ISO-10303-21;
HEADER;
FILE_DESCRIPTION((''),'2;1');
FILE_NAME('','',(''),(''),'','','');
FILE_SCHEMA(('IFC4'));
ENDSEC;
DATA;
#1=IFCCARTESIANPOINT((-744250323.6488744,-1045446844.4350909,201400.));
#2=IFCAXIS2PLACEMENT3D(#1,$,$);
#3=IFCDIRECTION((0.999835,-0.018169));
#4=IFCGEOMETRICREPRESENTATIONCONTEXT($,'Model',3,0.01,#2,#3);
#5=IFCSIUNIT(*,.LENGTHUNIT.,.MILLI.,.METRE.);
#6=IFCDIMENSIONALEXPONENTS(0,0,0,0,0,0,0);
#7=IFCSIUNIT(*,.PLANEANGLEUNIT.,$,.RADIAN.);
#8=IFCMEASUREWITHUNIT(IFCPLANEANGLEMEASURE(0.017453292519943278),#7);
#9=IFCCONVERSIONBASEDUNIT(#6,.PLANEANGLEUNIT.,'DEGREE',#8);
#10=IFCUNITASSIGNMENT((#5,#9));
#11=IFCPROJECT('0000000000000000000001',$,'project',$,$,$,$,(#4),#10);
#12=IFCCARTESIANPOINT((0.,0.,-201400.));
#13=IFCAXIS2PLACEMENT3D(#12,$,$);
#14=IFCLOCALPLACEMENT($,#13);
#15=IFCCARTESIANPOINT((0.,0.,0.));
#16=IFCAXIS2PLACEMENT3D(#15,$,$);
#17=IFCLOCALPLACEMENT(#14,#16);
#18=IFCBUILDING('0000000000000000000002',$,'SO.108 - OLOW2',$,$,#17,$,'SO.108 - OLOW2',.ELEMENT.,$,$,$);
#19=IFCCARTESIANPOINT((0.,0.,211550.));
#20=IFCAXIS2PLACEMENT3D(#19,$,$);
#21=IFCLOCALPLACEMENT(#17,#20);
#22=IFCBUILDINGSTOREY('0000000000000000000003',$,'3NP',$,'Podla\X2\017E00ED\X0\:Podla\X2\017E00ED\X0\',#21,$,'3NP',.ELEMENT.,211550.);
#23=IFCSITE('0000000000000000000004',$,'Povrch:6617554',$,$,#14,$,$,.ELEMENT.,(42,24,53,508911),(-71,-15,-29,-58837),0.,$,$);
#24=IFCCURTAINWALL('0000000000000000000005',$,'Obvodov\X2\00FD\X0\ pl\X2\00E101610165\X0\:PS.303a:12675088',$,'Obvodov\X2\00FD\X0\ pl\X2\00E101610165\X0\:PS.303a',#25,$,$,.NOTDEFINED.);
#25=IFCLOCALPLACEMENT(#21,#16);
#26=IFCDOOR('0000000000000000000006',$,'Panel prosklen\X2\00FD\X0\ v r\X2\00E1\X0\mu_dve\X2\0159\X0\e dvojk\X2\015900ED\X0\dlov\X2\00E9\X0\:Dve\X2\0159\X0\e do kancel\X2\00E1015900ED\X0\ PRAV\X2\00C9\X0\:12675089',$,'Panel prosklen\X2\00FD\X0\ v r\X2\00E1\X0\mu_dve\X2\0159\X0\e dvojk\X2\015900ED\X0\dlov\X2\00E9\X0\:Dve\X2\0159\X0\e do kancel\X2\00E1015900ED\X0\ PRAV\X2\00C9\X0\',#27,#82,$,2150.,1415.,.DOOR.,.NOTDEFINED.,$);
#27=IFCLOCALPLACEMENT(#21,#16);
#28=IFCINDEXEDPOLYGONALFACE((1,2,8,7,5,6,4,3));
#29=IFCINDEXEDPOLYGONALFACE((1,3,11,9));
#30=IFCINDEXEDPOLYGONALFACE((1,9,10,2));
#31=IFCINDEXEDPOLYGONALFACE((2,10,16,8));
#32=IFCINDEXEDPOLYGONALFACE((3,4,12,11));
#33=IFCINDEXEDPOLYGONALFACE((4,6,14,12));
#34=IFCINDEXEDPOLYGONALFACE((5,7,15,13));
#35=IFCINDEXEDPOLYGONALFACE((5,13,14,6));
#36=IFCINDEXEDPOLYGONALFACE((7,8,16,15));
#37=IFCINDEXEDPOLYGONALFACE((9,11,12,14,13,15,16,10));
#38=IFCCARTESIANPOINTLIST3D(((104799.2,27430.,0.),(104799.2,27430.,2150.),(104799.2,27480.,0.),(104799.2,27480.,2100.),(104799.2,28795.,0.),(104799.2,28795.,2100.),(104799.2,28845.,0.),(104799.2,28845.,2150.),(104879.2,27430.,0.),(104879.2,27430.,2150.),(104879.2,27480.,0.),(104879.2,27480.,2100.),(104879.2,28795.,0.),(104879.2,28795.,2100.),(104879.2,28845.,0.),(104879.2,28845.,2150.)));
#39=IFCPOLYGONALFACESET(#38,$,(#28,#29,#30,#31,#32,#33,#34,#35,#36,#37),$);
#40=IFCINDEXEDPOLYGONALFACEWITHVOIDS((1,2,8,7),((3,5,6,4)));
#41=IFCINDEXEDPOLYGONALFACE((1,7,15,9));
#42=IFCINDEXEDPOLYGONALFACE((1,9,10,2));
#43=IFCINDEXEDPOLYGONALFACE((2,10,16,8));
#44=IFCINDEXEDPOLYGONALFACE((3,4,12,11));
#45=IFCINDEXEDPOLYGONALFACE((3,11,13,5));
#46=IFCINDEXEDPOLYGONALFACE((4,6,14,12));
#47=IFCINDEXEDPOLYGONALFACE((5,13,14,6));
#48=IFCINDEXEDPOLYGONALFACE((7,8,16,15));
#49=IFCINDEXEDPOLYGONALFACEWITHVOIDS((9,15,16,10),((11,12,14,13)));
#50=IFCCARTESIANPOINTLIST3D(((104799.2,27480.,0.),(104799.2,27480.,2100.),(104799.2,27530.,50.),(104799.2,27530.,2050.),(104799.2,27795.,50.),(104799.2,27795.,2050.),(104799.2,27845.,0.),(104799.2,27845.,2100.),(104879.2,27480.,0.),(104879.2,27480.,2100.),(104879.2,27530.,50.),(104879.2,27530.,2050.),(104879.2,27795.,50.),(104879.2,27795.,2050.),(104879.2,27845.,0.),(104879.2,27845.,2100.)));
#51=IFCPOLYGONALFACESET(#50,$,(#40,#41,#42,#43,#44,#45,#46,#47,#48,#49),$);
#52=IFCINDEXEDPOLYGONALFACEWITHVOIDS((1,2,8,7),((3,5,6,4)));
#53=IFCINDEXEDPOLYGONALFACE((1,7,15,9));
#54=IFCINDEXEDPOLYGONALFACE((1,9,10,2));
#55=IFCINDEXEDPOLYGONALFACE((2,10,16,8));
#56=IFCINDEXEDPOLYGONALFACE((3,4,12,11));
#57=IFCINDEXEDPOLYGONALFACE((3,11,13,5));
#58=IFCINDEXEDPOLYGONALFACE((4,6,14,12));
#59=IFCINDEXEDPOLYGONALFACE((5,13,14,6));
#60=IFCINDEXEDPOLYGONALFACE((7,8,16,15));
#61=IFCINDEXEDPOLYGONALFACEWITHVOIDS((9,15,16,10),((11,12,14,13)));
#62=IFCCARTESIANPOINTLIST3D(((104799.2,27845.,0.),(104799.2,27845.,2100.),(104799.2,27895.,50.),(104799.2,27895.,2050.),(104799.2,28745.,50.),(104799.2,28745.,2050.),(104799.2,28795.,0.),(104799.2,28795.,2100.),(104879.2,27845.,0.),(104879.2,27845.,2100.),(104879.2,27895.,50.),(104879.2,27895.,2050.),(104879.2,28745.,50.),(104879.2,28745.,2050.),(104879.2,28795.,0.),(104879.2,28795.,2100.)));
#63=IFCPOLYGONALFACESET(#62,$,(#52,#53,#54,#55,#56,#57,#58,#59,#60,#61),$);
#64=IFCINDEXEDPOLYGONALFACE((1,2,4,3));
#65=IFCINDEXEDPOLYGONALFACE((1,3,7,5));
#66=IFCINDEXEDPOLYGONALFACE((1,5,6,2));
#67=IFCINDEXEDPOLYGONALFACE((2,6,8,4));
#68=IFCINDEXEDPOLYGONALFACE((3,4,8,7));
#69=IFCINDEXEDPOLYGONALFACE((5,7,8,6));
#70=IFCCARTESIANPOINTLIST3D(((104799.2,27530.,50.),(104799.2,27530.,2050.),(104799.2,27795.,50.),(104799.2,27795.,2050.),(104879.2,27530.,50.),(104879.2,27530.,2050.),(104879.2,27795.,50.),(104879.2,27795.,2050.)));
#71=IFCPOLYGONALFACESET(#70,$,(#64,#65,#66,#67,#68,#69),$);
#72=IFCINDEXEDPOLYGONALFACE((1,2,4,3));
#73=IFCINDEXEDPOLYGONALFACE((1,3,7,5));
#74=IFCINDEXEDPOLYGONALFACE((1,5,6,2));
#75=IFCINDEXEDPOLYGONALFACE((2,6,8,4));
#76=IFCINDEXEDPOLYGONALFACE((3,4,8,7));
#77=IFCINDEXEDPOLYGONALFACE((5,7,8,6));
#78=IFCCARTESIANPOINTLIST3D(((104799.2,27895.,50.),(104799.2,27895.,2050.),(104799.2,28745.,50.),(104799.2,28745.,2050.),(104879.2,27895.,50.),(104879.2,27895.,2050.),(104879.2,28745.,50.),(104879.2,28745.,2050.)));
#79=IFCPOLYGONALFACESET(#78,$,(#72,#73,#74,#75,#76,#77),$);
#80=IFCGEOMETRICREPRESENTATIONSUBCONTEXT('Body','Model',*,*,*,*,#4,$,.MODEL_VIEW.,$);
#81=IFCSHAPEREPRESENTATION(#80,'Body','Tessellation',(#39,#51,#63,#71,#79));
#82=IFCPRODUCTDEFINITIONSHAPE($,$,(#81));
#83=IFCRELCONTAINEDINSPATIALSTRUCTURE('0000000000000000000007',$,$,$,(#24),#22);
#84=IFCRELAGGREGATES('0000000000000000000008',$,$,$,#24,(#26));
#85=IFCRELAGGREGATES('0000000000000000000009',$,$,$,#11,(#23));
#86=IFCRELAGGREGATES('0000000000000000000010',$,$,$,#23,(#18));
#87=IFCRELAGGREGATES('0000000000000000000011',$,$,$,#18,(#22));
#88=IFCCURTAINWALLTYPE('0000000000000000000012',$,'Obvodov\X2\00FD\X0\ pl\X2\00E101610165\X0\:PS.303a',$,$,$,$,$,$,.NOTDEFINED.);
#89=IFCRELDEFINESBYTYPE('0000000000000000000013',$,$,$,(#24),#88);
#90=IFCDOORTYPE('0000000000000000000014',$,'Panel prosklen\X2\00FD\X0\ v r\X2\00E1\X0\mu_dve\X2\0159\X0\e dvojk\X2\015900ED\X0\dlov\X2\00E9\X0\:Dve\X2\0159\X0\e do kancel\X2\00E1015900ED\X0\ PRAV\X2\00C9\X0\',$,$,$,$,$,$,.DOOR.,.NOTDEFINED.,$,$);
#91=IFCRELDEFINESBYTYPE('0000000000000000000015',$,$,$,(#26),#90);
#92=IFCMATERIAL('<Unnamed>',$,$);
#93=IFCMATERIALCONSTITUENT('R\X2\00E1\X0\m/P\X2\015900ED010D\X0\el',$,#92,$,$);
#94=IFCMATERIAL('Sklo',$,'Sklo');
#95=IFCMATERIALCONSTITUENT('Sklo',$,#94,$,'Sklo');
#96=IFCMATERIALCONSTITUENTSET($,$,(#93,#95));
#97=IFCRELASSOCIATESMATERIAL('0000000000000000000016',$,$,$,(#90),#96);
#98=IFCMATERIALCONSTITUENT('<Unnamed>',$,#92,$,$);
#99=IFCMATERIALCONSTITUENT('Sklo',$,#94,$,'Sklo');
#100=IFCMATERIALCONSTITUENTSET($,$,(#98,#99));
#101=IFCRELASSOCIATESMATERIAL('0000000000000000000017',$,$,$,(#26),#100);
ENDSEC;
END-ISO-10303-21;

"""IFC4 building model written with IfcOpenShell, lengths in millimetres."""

from ifc_helpers import new_model, entity, si_unit, converted_unit, direction, frame, origin, place, context, subcontext, project, spatial, indexed_curve, outline, extrude, source, transform, mapped, material, constituent, constituent_set, type_object, type_shapes, element, aggregate, save


model = new_model("IFC4")

# Units and contexts
model_context = context("Model", 3, precision=0.01, world=frame((-744250323.6488744, -1045446844.4350909, 201400.0)), true_north=direction((0.999835, -0.018169)))
body_context = subcontext(model_context, "Body", "Model", "MODEL_VIEW")
ifc_project = project(units=[si_unit("LENGTHUNIT", "METRE", prefix="MILLI"), converted_unit("PLANEANGLEUNIT", "DEGREE", entity("IfcPlaneAngleMeasure", 0.017453292519943278), si_unit("PLANEANGLEUNIT", "RADIAN"), dimensions=[0, 0, 0, 0, 0, 0, 0])], contexts=[model_context])

# Site, building, storey
site_placement = place(None, frame((0.0, 0.0, -201400.0)))
site = spatial("IfcSite", under=ifc_project, at=site_placement, Name="Povrch:6617554", CompositionType="ELEMENT", RefLatitude=(42, 24, 53, 508911), RefLongitude=(-71, -15, -29, -58837), RefElevation=0.0)
building_placement = place(site_placement, origin())
building = spatial("IfcBuilding", under=site, at=building_placement, Name="SO.108 - OLOW2", LongName="SO.108 - OLOW2", CompositionType="ELEMENT")
storey_placement = place(building_placement, frame((0.0, 0.0, 211550.0)))
storey = spatial("IfcBuildingStorey", under=building, at=storey_placement, Name="3NP", ObjectType="Podlaží:Podlaží", LongName="3NP", CompositionType="ELEMENT", Elevation=211550.0)

# Shared definitions
ifc_material_1 = material(Name="<Unnamed>")

# Curtain wall
curtain_wall_type_1 = type_object("IfcCurtainWallType", Name="Obvodový plášť:PS.303a", PredefinedType="NOTDEFINED")
curtain_wall_1_placement = place(storey_placement, frame((0.0, 0.0, -211550.0)))
curtain_wall_1 = element("IfcCurtainWall", 1, at=curtain_wall_1_placement, inside=storey, type_object=curtain_wall_type_1, Name="Obvodový plášť:PS.303a:12675088", ObjectType="Obvodový plášť:PS.303a", PredefinedType="NOTDEFINED")

# Shared definitions
ifc_material_2 = material(Name="Sklo", Category="Sklo")

# Door
ifc_constituent_1 = constituent(ifc_material_1, Name="<Unnamed>")
ifc_constituent_2 = constituent(ifc_material_2, Name="Sklo", Category="Sklo")
ifc_constituent_set_1 = constituent_set(constituents=[ifc_constituent_1, ifc_constituent_2])
ifc_constituent_3 = constituent(ifc_material_1, Name="Rám/Příčel")
ifc_constituent_4 = constituent(ifc_material_2, Name="Sklo", Category="Sklo")
ifc_constituent_set_2 = constituent_set(constituents=[ifc_constituent_3, ifc_constituent_4])
door_type = type_object("IfcDoorType", Name="Panel prosklený v rámu_dveře dvojkřídlové:Dveře do kanceláří PRAVÉ", OperationType="NOTDEFINED", PredefinedType="DOOR", material=ifc_constituent_set_2)
shared_shape_1 = source(origin(), body_context, "Body", "SweptSolid", [
    extrude(outline(indexed_curve([(-707.5, -1087.5), (707.5, -1087.5), (707.5, 1062.5), (657.5, 1062.5), (657.5, -1037.5), (-657.5, -1037.5), (-657.5, 1062.5), (-707.5, 1062.5), (-707.5, -1087.5)], self_intersect=False)), frame((0.0, -40.0, 1062.5), z_axis=(0.0, 1.0, 0.0), x_axis=(1.0, 0.0, 0.0)), (0.0, 0.0, 1.0), 80.0),
    extrude(outline(indexed_curve([(-1050.0, -182.5), (1050.0, -182.5), (1050.0, 182.5), (-1050.0, 182.5), (-1050.0, -182.5)], self_intersect=False), holes=[indexed_curve([(-1000.0, -132.5), (-1000.0, 132.5), (1000.0, 132.5), (1000.0, -132.5), (-1000.0, -132.5)], self_intersect=False)]), frame((475.0, -40.0, 1050.0), z_axis=(0.0, 1.0, 0.0), x_axis=(0.0, 0.0, -1.0)), (0.0, 0.0, 1.0), 80.0),
    extrude(outline(indexed_curve([(-1050.0, -475.0), (1050.0, -475.0), (1050.0, 475.0), (-1050.0, 475.0), (-1050.0, -475.0)], self_intersect=False), holes=[indexed_curve([(-1000.0, -425.0), (-1000.0, 425.0), (1000.0, 425.0), (1000.0, -425.0), (-1000.0, -425.0)], self_intersect=False)]), frame((-182.5, -40.0, 1050.0), z_axis=(0.0, 1.0, 0.0), x_axis=(0.0, 0.0, -1.0)), (0.0, 0.0, 1.0), 80.0),
    extrude(outline(indexed_curve([(-40.0, -132.5), (40.0, -132.5), (40.0, 132.5), (-40.0, 132.5), (-40.0, -132.5)], self_intersect=False)), frame((475.0, 0.0, 50.0), z_axis=(0.0, 0.0, 1.0), x_axis=(0.0, 1.0, 0.0)), (0.0, 0.0, 1.0), 2000.0),
    extrude(outline(indexed_curve([(-40.0, -425.0), (40.0, -425.0), (40.0, 425.0), (-40.0, 425.0), (-40.0, -425.0)], self_intersect=False)), frame((-182.5, 0.0, 50.0), z_axis=(0.0, 0.0, 1.0), x_axis=(0.0, 1.0, 0.0)), (0.0, 0.0, 1.0), 2000.0),
])
type_shapes(door_type, [shared_shape_1])
door_placement = place(curtain_wall_1_placement, frame((104839.2, 28137.5, 211550.0), z_axis=(0.0, 0.0, 1.0), x_axis=(0.0, -1.0, 0.0)))
door = element("IfcDoor", 2, at=door_placement, type_object=door_type, material=ifc_constituent_set_1, Name="Panel prosklený v rámu_dveře dvojkřídlové:Dveře do kanceláří PRAVÉ:12675089", ObjectType="Panel prosklený v rámu_dveře dvojkřídlové:Dveře do kanceláří PRAVÉ", OperationType="NOTDEFINED", OverallHeight=2150.0, OverallWidth=1415.0, PredefinedType="DOOR", context=body_context, shape_type="MappedRepresentation", body=[
    mapped(shared_shape_1, transform((0.0, 0.0, 0.0), scale=1.0)),
])
aggregate(curtain_wall_1, [door])

save(model, "model.ifc")
